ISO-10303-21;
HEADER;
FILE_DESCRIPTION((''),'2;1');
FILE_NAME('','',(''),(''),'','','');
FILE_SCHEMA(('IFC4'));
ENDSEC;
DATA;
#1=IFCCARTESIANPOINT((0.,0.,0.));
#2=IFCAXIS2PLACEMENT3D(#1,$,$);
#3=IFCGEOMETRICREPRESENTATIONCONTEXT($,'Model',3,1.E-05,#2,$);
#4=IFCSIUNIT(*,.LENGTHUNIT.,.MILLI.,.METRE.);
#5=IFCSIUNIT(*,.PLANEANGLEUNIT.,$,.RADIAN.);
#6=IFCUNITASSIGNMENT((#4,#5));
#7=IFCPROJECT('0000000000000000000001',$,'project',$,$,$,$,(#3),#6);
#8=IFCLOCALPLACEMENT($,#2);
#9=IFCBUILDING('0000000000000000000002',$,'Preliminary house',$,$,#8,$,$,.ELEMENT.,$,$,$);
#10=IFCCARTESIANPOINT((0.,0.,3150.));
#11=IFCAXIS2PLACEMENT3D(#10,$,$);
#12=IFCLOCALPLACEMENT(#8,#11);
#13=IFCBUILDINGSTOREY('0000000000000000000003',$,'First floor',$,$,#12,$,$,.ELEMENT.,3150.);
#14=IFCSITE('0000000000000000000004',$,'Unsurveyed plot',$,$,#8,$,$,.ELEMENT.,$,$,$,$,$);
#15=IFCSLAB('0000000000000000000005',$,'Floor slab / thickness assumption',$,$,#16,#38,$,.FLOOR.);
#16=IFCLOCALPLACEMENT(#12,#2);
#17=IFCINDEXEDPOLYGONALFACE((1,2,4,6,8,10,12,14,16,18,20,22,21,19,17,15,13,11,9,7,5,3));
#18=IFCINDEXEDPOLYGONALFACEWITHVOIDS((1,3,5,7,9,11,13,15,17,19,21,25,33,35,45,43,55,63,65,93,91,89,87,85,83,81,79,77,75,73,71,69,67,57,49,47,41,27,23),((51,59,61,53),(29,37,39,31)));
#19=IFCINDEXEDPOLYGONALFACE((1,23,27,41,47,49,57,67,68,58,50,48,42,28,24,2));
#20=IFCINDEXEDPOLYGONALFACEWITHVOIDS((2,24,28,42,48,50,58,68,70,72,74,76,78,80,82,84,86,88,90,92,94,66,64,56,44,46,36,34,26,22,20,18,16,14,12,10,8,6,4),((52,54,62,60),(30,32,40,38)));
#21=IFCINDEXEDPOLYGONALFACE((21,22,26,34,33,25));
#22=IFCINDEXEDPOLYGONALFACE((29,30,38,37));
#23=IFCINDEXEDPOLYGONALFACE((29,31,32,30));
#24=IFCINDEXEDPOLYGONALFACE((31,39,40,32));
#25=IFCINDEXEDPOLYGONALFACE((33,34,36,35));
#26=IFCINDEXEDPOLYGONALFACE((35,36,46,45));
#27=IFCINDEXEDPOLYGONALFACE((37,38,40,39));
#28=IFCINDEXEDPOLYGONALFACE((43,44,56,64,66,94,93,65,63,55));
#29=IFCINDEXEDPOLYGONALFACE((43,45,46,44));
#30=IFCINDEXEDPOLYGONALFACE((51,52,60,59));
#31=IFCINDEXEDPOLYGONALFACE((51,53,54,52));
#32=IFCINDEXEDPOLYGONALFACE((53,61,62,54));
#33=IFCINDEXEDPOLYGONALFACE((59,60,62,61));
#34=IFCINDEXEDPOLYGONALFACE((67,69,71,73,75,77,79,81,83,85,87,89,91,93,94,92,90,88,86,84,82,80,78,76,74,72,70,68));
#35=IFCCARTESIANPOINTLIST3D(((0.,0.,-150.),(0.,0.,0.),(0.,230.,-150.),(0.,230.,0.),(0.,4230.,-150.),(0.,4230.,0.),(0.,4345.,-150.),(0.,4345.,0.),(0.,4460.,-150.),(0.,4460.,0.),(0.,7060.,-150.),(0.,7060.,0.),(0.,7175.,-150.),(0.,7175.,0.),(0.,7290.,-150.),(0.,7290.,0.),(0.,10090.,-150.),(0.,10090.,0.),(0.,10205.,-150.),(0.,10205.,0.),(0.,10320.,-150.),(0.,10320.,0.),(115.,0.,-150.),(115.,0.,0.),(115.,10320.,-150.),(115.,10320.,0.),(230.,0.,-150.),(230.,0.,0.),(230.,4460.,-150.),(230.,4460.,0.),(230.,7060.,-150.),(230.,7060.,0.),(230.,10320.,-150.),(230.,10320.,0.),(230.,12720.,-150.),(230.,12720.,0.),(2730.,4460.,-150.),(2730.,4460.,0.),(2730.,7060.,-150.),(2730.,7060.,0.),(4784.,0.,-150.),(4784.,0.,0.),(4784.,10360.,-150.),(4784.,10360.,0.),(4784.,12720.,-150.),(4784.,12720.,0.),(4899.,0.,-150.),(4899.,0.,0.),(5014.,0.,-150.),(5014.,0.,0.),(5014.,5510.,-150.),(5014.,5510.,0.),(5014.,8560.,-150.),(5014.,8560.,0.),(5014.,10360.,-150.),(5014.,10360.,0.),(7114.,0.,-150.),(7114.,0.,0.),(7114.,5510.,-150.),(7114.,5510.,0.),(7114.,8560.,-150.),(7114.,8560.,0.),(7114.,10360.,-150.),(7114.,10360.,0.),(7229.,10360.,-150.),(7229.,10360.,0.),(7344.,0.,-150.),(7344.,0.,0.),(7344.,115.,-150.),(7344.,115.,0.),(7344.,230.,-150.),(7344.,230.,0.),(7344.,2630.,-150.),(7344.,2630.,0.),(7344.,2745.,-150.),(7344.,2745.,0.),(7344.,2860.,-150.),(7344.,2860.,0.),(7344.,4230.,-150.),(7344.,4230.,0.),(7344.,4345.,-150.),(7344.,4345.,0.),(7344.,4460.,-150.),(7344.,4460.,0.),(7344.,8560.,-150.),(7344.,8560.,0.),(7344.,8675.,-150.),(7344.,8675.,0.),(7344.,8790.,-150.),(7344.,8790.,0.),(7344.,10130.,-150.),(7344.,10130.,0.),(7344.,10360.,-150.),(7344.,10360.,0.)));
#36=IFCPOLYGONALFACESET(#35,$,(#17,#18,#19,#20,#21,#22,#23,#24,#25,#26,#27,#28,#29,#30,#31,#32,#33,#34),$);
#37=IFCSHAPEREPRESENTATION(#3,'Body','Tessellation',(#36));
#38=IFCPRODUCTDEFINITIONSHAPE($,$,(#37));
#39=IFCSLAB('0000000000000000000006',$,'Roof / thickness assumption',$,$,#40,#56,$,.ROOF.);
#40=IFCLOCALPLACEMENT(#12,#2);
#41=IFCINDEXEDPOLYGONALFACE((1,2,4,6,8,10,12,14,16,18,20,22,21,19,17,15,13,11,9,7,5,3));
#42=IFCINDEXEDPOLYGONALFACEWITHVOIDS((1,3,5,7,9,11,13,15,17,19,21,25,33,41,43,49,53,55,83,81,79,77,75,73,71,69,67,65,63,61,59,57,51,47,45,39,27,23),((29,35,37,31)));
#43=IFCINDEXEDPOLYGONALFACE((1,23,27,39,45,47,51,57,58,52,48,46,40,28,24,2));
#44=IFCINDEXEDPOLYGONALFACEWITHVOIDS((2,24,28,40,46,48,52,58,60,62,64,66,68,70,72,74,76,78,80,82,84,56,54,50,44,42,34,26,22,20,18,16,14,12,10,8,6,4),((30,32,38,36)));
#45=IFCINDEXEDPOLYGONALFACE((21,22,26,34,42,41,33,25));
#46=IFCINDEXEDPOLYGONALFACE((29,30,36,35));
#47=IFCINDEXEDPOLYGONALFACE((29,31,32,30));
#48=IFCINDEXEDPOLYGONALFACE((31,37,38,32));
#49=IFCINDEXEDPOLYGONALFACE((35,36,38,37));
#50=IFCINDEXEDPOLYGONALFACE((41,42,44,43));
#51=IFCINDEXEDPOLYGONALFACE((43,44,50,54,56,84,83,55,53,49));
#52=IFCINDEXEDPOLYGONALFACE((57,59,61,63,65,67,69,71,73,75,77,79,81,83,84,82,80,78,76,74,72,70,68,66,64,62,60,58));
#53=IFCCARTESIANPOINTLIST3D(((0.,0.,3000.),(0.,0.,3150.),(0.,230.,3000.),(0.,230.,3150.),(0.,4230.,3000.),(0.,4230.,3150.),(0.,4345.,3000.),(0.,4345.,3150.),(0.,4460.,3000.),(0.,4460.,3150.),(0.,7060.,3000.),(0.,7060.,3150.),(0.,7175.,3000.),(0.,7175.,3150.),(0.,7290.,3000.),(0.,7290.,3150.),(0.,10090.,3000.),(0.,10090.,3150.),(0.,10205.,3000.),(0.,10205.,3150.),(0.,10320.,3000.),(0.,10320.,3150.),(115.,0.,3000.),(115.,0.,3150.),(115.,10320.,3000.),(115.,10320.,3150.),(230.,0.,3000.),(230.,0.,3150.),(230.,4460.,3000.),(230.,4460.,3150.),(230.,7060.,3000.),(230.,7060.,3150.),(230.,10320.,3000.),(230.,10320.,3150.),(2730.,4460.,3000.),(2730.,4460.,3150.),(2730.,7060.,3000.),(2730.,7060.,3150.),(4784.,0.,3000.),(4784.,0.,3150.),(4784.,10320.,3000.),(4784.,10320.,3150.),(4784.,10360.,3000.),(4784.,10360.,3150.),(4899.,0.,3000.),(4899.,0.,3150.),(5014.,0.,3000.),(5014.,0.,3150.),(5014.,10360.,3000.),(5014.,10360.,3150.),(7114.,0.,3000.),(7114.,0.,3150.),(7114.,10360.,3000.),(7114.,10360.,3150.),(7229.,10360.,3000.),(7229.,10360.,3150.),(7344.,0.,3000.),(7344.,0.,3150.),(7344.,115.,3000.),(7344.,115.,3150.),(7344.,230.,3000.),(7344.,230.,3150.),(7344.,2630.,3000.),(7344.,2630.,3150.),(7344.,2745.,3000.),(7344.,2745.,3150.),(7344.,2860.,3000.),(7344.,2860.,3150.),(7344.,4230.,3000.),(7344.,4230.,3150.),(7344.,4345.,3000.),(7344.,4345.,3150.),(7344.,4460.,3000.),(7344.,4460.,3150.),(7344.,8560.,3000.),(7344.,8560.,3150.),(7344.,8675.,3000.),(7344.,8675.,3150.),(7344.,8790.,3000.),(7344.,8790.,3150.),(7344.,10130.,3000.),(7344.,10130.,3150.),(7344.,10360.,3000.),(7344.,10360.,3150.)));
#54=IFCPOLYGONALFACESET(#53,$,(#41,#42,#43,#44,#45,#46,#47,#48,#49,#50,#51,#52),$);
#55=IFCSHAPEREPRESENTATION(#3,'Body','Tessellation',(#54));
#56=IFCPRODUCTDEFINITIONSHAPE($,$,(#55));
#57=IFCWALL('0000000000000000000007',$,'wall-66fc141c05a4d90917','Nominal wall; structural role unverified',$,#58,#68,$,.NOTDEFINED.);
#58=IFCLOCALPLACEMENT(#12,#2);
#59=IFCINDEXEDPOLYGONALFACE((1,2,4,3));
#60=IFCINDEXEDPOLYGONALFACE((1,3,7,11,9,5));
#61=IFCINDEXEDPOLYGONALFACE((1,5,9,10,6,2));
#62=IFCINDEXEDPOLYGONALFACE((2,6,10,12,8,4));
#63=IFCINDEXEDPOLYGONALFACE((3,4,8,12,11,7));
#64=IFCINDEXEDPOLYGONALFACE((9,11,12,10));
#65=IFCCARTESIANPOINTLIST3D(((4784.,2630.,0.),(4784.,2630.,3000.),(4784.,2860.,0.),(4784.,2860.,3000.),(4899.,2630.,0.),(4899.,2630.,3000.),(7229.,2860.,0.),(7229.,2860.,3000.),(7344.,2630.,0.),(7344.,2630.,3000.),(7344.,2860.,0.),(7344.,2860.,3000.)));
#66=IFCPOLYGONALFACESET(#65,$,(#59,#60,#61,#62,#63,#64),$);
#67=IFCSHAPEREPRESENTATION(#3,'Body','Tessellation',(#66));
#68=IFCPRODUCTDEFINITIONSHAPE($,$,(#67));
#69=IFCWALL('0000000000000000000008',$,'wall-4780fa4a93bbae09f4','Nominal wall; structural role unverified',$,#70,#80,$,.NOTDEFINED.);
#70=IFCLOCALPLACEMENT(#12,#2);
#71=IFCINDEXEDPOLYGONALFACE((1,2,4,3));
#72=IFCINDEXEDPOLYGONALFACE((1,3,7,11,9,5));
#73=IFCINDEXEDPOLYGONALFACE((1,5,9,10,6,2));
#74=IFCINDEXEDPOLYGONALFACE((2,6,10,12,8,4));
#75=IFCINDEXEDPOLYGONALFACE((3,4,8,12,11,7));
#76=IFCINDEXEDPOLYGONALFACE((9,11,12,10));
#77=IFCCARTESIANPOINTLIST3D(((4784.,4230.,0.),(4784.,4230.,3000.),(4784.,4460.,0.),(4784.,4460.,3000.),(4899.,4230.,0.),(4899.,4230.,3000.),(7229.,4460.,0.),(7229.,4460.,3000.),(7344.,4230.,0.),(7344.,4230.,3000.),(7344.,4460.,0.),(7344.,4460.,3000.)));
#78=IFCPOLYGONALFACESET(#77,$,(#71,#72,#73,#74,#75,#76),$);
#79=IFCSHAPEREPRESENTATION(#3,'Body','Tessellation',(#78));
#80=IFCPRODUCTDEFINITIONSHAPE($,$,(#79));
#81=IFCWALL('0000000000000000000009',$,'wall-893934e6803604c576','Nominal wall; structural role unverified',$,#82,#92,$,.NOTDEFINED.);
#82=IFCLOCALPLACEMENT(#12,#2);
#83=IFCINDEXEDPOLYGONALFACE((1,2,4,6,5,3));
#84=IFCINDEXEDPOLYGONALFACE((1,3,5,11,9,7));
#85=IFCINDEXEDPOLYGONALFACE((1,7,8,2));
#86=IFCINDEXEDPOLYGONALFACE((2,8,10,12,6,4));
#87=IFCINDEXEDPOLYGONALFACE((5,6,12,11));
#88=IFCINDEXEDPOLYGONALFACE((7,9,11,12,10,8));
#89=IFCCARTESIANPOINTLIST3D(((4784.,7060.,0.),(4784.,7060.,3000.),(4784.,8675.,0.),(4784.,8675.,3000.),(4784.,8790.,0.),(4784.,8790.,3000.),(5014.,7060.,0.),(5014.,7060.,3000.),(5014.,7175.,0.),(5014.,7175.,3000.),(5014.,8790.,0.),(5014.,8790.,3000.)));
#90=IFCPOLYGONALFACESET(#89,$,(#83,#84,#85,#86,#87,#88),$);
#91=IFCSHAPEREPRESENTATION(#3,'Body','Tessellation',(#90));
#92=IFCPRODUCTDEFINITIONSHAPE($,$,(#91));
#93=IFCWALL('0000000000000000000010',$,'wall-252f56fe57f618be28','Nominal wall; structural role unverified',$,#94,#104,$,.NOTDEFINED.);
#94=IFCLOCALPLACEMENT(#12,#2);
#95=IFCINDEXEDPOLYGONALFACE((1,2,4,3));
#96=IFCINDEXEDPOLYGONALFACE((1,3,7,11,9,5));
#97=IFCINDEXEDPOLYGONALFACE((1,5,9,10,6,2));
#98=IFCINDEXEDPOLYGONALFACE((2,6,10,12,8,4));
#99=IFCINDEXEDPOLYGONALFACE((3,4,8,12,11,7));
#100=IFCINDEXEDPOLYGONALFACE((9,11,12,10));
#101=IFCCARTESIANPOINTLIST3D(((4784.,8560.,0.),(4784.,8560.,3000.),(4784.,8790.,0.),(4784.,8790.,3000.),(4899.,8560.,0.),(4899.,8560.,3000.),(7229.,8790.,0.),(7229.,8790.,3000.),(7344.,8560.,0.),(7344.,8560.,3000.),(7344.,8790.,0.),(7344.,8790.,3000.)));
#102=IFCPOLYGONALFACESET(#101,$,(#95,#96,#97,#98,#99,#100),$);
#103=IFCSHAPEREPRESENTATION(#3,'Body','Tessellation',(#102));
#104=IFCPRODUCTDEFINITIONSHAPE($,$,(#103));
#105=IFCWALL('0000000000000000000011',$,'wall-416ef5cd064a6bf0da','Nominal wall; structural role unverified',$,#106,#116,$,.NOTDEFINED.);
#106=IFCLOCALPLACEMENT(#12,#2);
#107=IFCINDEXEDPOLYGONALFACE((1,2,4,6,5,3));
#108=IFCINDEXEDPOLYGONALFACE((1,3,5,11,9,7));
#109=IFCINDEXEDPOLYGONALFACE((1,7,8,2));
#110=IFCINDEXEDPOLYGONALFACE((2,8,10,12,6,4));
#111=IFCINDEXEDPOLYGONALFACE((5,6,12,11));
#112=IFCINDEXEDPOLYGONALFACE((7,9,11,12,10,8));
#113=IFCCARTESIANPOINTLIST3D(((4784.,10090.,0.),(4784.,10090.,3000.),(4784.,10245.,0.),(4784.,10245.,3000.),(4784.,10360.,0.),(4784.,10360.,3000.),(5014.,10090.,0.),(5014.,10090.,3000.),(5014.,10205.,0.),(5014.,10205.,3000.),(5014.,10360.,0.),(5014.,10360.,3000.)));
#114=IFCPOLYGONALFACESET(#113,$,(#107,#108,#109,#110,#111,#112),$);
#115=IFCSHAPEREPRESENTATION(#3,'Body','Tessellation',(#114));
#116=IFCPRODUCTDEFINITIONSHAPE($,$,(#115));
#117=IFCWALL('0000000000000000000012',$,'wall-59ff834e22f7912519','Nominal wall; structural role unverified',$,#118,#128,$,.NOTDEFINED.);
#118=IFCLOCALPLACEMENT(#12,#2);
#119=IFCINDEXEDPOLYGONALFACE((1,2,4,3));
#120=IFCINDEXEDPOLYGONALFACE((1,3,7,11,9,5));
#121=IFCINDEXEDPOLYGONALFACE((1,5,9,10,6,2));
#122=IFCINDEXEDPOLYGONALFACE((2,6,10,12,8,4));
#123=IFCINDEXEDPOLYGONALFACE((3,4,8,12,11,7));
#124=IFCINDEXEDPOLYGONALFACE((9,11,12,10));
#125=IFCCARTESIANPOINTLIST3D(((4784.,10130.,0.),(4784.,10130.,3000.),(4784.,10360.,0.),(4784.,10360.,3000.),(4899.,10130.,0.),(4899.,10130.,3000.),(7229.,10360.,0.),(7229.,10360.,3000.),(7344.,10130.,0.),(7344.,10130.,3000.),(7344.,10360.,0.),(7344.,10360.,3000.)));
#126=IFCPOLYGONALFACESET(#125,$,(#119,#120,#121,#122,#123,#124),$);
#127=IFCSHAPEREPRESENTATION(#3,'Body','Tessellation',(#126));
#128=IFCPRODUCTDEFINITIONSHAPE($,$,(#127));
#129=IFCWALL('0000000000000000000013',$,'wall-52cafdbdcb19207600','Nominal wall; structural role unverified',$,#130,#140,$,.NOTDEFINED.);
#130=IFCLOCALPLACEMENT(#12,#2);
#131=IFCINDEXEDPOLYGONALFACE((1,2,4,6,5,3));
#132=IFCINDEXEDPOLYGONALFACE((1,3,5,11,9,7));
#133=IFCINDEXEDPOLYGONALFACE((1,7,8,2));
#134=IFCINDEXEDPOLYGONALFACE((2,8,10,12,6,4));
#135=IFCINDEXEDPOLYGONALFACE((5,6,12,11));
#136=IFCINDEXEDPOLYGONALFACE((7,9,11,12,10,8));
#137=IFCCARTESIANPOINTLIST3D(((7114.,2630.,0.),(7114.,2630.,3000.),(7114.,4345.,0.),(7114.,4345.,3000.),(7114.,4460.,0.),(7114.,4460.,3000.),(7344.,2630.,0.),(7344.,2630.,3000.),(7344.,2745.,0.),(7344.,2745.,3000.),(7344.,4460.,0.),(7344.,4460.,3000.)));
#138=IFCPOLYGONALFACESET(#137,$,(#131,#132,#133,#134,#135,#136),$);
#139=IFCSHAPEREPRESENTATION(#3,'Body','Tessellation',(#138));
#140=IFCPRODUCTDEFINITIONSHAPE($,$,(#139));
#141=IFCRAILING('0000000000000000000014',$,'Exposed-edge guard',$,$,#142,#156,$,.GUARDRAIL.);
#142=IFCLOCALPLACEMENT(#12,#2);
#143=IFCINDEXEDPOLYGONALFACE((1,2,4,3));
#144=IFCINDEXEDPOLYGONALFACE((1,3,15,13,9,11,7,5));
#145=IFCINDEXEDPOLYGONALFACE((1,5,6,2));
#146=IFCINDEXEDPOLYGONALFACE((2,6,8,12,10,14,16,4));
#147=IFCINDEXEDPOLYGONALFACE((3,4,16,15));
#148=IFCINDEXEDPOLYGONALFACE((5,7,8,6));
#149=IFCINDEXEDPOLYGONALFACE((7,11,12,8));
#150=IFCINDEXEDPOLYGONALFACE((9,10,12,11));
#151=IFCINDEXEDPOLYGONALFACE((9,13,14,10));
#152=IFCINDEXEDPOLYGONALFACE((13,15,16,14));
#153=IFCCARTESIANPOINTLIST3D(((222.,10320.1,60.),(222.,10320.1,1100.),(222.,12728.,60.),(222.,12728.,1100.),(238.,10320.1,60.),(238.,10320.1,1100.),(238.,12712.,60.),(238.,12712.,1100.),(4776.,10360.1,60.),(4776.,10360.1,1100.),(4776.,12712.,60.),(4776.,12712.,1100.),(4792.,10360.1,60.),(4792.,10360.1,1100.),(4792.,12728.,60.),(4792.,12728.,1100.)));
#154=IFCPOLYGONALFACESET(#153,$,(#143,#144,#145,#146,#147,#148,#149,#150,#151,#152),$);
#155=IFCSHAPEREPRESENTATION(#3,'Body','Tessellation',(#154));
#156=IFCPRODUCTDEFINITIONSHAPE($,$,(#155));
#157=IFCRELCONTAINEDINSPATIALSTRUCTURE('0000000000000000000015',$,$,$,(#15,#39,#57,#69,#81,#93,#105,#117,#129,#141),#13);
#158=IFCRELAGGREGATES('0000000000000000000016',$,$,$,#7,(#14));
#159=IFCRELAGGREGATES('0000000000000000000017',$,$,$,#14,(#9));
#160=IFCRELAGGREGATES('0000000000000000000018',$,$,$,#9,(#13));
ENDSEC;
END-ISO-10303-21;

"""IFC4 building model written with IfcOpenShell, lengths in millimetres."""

from ifc_helpers import new_model, si_unit, frame, origin, place, context, project, spatial, polyline, outline, extrude, element, save


model = new_model("IFC4")

# Units and contexts
model_context = context("Model", 3, precision=1e-05, world=origin())
ifc_project = project(units=[si_unit("LENGTHUNIT", "METRE", prefix="MILLI"), si_unit("PLANEANGLEUNIT", "RADIAN")], contexts=[model_context])

# Site, building, storey
placement_1 = place(None, origin())
site = spatial("IfcSite", under=ifc_project, at=placement_1, Name="Unsurveyed plot", CompositionType="ELEMENT")
building = spatial("IfcBuilding", under=site, at=placement_1, Name="Preliminary house", CompositionType="ELEMENT")
placement_2 = place(placement_1, frame((0.0, 0.0, 3150.0)))
storey = spatial("IfcBuildingStorey", under=building, at=placement_2, Name="First floor", CompositionType="ELEMENT", Elevation=3150.0)

# Slabs
element("IfcSlab", 1, at=placement_2, inside=storey, Name="Floor slab / thickness assumption", PredefinedType="FLOOR", context=model_context, shape_type="SweptSolid", body=[
    extrude(outline(polyline([(0.0, 0.0), (0.0, 230.0), (0.0, 4230.0), (0.0, 4345.0), (0.0, 4460.0), (0.0, 7060.0), (0.0, 7175.0), (0.0, 7290.0), (0.0, 10090.0), (0.0, 10205.0), (0.0, 10320.0), (115.0, 10320.0), (230.0, 10320.0), (230.0, 12720.0), (4784.0, 12720.0), (4784.0, 10360.0), (5014.0, 10360.0), (7114.0, 10360.0), (7229.0, 10360.0), (7344.0, 10360.0), (7344.0, 10130.0), (7344.0, 8790.0), (7344.0, 8675.0), (7344.0, 8560.0), (7344.0, 4460.0), (7344.0, 4345.0), (7344.0, 4230.0), (7344.0, 2860.0), (7344.0, 2745.0), (7344.0, 2630.0), (7344.0, 230.0), (7344.0, 115.0), (7344.0, 0.0), (7114.0, 0.0), (5014.0, 0.0), (4899.0, 0.0), (4784.0, 0.0), (230.0, 0.0), (115.0, 0.0), (0.0, 0.0)]), holes=[polyline([(230.0, 7060.0), (230.0, 4460.0), (2730.0, 4460.0), (2730.0, 7060.0), (230.0, 7060.0)]), polyline([(7114.0, 8560.0), (5014.0, 8560.0), (5014.0, 5510.0), (7114.0, 5510.0), (7114.0, 8560.0)])]), frame((0.0, 0.0, -150.0)), (0.0, 0.0, 1.0), 150.0),
])
element("IfcSlab", 2, at=placement_2, inside=storey, Name="Roof / thickness assumption", PredefinedType="ROOF", context=model_context, shape_type="SweptSolid", body=[
    extrude(outline(polyline([(0.0, 0.0), (0.0, 230.0), (0.0, 4230.0), (0.0, 4345.0), (0.0, 4460.0), (0.0, 7060.0), (0.0, 7175.0), (0.0, 7290.0), (0.0, 10090.0), (0.0, 10205.0), (0.0, 10320.0), (115.0, 10320.0), (230.0, 10320.0), (4784.0, 10320.0), (4784.0, 10360.0), (5014.0, 10360.0), (7114.0, 10360.0), (7229.0, 10360.0), (7344.0, 10360.0), (7344.0, 10130.0), (7344.0, 8790.0), (7344.0, 8675.0), (7344.0, 8560.0), (7344.0, 4460.0), (7344.0, 4345.0), (7344.0, 4230.0), (7344.0, 2860.0), (7344.0, 2745.0), (7344.0, 2630.0), (7344.0, 230.0), (7344.0, 115.0), (7344.0, 0.0), (7114.0, 0.0), (5014.0, 0.0), (4899.0, 0.0), (4784.0, 0.0), (230.0, 0.0), (115.0, 0.0), (0.0, 0.0)]), holes=[polyline([(230.0, 7060.0), (230.0, 4460.0), (2730.0, 4460.0), (2730.0, 7060.0), (230.0, 7060.0)])]), frame((0.0, 0.0, 3000.0)), (0.0, 0.0, 1.0), 150.0),
])

# Wall
element("IfcWall", 3, at=placement_2, inside=storey, Name="wall-66fc141c05a4d90917", Description="Nominal wall; structural role unverified", PredefinedType="NOTDEFINED", context=model_context, shape_type="SweptSolid", body=[
    extrude(outline(polyline([(7229.0, 2860.0), (7344.0, 2860.0), (7344.0, 2630.0), (4899.0, 2630.0), (4784.0, 2630.0), (4784.0, 2860.0), (7229.0, 2860.0)])), origin(), (0.0, 0.0, 1.0), 3000.0),
])

# Walls
element("IfcWall", 4, at=placement_2, inside=storey, Name="wall-4780fa4a93bbae09f4", Description="Nominal wall; structural role unverified", PredefinedType="NOTDEFINED", context=model_context, shape_type="SweptSolid", body=[
    extrude(outline(polyline([(7229.0, 4460.0), (7344.0, 4460.0), (7344.0, 4230.0), (4899.0, 4230.0), (4784.0, 4230.0), (4784.0, 4460.0), (7229.0, 4460.0)])), origin(), (0.0, 0.0, 1.0), 3000.0),
])
element("IfcWall", 5, at=placement_2, inside=storey, Name="wall-893934e6803604c576", Description="Nominal wall; structural role unverified", PredefinedType="NOTDEFINED", context=model_context, shape_type="SweptSolid", body=[
    extrude(outline(polyline([(4784.0, 8675.0), (4784.0, 8790.0), (5014.0, 8790.0), (5014.0, 7175.0), (5014.0, 7060.0), (4784.0, 7060.0), (4784.0, 8675.0)])), origin(), (0.0, 0.0, 1.0), 3000.0),
])

# Walls
element("IfcWall", 6, at=placement_2, inside=storey, Name="wall-252f56fe57f618be28", Description="Nominal wall; structural role unverified", PredefinedType="NOTDEFINED", context=model_context, shape_type="SweptSolid", body=[
    extrude(outline(polyline([(7229.0, 8790.0), (7344.0, 8790.0), (7344.0, 8560.0), (4899.0, 8560.0), (4784.0, 8560.0), (4784.0, 8790.0), (7229.0, 8790.0)])), origin(), (0.0, 0.0, 1.0), 3000.0),
])
element("IfcWall", 7, at=placement_2, inside=storey, Name="wall-416ef5cd064a6bf0da", Description="Nominal wall; structural role unverified", PredefinedType="NOTDEFINED", context=model_context, shape_type="SweptSolid", body=[
    extrude(outline(polyline([(4784.0, 10245.0), (4784.0, 10360.0), (5014.0, 10360.0), (5014.0, 10205.0), (5014.0, 10090.0), (4784.0, 10090.0), (4784.0, 10245.0)])), origin(), (0.0, 0.0, 1.0), 3000.0),
])
element("IfcWall", 8, at=placement_2, inside=storey, Name="wall-59ff834e22f7912519", Description="Nominal wall; structural role unverified", PredefinedType="NOTDEFINED", context=model_context, shape_type="SweptSolid", body=[
    extrude(outline(polyline([(7229.0, 10360.0), (7344.0, 10360.0), (7344.0, 10130.0), (4899.0, 10130.0), (4784.0, 10130.0), (4784.0, 10360.0), (7229.0, 10360.0)])), origin(), (0.0, 0.0, 1.0), 3000.0),
])

# Wall
element("IfcWall", 9, at=placement_2, inside=storey, Name="wall-52cafdbdcb19207600", Description="Nominal wall; structural role unverified", PredefinedType="NOTDEFINED", context=model_context, shape_type="SweptSolid", body=[
    extrude(outline(polyline([(7114.0, 4345.0), (7114.0, 4460.0), (7344.0, 4460.0), (7344.0, 2745.0), (7344.0, 2630.0), (7114.0, 2630.0), (7114.0, 4345.0)])), origin(), (0.0, 0.0, 1.0), 3000.0),
])

# Railing
element("IfcRailing", 10, at=placement_2, inside=storey, Name="Exposed-edge guard", PredefinedType="GUARDRAIL", context=model_context, shape_type="SweptSolid", body=[
    extrude(outline(polyline([(4776.0, 12712.0), (238.0, 12712.0), (238.0, 10320.1), (222.0, 10320.1), (222.0, 12728.0), (4792.0, 12728.0), (4792.0, 10360.1), (4776.0, 10360.1), (4776.0, 12712.0)])), frame((0.0, 0.0, 60.0)), (0.0, 0.0, 1.0), 1040.0),
])

save(model, "model.ifc")
